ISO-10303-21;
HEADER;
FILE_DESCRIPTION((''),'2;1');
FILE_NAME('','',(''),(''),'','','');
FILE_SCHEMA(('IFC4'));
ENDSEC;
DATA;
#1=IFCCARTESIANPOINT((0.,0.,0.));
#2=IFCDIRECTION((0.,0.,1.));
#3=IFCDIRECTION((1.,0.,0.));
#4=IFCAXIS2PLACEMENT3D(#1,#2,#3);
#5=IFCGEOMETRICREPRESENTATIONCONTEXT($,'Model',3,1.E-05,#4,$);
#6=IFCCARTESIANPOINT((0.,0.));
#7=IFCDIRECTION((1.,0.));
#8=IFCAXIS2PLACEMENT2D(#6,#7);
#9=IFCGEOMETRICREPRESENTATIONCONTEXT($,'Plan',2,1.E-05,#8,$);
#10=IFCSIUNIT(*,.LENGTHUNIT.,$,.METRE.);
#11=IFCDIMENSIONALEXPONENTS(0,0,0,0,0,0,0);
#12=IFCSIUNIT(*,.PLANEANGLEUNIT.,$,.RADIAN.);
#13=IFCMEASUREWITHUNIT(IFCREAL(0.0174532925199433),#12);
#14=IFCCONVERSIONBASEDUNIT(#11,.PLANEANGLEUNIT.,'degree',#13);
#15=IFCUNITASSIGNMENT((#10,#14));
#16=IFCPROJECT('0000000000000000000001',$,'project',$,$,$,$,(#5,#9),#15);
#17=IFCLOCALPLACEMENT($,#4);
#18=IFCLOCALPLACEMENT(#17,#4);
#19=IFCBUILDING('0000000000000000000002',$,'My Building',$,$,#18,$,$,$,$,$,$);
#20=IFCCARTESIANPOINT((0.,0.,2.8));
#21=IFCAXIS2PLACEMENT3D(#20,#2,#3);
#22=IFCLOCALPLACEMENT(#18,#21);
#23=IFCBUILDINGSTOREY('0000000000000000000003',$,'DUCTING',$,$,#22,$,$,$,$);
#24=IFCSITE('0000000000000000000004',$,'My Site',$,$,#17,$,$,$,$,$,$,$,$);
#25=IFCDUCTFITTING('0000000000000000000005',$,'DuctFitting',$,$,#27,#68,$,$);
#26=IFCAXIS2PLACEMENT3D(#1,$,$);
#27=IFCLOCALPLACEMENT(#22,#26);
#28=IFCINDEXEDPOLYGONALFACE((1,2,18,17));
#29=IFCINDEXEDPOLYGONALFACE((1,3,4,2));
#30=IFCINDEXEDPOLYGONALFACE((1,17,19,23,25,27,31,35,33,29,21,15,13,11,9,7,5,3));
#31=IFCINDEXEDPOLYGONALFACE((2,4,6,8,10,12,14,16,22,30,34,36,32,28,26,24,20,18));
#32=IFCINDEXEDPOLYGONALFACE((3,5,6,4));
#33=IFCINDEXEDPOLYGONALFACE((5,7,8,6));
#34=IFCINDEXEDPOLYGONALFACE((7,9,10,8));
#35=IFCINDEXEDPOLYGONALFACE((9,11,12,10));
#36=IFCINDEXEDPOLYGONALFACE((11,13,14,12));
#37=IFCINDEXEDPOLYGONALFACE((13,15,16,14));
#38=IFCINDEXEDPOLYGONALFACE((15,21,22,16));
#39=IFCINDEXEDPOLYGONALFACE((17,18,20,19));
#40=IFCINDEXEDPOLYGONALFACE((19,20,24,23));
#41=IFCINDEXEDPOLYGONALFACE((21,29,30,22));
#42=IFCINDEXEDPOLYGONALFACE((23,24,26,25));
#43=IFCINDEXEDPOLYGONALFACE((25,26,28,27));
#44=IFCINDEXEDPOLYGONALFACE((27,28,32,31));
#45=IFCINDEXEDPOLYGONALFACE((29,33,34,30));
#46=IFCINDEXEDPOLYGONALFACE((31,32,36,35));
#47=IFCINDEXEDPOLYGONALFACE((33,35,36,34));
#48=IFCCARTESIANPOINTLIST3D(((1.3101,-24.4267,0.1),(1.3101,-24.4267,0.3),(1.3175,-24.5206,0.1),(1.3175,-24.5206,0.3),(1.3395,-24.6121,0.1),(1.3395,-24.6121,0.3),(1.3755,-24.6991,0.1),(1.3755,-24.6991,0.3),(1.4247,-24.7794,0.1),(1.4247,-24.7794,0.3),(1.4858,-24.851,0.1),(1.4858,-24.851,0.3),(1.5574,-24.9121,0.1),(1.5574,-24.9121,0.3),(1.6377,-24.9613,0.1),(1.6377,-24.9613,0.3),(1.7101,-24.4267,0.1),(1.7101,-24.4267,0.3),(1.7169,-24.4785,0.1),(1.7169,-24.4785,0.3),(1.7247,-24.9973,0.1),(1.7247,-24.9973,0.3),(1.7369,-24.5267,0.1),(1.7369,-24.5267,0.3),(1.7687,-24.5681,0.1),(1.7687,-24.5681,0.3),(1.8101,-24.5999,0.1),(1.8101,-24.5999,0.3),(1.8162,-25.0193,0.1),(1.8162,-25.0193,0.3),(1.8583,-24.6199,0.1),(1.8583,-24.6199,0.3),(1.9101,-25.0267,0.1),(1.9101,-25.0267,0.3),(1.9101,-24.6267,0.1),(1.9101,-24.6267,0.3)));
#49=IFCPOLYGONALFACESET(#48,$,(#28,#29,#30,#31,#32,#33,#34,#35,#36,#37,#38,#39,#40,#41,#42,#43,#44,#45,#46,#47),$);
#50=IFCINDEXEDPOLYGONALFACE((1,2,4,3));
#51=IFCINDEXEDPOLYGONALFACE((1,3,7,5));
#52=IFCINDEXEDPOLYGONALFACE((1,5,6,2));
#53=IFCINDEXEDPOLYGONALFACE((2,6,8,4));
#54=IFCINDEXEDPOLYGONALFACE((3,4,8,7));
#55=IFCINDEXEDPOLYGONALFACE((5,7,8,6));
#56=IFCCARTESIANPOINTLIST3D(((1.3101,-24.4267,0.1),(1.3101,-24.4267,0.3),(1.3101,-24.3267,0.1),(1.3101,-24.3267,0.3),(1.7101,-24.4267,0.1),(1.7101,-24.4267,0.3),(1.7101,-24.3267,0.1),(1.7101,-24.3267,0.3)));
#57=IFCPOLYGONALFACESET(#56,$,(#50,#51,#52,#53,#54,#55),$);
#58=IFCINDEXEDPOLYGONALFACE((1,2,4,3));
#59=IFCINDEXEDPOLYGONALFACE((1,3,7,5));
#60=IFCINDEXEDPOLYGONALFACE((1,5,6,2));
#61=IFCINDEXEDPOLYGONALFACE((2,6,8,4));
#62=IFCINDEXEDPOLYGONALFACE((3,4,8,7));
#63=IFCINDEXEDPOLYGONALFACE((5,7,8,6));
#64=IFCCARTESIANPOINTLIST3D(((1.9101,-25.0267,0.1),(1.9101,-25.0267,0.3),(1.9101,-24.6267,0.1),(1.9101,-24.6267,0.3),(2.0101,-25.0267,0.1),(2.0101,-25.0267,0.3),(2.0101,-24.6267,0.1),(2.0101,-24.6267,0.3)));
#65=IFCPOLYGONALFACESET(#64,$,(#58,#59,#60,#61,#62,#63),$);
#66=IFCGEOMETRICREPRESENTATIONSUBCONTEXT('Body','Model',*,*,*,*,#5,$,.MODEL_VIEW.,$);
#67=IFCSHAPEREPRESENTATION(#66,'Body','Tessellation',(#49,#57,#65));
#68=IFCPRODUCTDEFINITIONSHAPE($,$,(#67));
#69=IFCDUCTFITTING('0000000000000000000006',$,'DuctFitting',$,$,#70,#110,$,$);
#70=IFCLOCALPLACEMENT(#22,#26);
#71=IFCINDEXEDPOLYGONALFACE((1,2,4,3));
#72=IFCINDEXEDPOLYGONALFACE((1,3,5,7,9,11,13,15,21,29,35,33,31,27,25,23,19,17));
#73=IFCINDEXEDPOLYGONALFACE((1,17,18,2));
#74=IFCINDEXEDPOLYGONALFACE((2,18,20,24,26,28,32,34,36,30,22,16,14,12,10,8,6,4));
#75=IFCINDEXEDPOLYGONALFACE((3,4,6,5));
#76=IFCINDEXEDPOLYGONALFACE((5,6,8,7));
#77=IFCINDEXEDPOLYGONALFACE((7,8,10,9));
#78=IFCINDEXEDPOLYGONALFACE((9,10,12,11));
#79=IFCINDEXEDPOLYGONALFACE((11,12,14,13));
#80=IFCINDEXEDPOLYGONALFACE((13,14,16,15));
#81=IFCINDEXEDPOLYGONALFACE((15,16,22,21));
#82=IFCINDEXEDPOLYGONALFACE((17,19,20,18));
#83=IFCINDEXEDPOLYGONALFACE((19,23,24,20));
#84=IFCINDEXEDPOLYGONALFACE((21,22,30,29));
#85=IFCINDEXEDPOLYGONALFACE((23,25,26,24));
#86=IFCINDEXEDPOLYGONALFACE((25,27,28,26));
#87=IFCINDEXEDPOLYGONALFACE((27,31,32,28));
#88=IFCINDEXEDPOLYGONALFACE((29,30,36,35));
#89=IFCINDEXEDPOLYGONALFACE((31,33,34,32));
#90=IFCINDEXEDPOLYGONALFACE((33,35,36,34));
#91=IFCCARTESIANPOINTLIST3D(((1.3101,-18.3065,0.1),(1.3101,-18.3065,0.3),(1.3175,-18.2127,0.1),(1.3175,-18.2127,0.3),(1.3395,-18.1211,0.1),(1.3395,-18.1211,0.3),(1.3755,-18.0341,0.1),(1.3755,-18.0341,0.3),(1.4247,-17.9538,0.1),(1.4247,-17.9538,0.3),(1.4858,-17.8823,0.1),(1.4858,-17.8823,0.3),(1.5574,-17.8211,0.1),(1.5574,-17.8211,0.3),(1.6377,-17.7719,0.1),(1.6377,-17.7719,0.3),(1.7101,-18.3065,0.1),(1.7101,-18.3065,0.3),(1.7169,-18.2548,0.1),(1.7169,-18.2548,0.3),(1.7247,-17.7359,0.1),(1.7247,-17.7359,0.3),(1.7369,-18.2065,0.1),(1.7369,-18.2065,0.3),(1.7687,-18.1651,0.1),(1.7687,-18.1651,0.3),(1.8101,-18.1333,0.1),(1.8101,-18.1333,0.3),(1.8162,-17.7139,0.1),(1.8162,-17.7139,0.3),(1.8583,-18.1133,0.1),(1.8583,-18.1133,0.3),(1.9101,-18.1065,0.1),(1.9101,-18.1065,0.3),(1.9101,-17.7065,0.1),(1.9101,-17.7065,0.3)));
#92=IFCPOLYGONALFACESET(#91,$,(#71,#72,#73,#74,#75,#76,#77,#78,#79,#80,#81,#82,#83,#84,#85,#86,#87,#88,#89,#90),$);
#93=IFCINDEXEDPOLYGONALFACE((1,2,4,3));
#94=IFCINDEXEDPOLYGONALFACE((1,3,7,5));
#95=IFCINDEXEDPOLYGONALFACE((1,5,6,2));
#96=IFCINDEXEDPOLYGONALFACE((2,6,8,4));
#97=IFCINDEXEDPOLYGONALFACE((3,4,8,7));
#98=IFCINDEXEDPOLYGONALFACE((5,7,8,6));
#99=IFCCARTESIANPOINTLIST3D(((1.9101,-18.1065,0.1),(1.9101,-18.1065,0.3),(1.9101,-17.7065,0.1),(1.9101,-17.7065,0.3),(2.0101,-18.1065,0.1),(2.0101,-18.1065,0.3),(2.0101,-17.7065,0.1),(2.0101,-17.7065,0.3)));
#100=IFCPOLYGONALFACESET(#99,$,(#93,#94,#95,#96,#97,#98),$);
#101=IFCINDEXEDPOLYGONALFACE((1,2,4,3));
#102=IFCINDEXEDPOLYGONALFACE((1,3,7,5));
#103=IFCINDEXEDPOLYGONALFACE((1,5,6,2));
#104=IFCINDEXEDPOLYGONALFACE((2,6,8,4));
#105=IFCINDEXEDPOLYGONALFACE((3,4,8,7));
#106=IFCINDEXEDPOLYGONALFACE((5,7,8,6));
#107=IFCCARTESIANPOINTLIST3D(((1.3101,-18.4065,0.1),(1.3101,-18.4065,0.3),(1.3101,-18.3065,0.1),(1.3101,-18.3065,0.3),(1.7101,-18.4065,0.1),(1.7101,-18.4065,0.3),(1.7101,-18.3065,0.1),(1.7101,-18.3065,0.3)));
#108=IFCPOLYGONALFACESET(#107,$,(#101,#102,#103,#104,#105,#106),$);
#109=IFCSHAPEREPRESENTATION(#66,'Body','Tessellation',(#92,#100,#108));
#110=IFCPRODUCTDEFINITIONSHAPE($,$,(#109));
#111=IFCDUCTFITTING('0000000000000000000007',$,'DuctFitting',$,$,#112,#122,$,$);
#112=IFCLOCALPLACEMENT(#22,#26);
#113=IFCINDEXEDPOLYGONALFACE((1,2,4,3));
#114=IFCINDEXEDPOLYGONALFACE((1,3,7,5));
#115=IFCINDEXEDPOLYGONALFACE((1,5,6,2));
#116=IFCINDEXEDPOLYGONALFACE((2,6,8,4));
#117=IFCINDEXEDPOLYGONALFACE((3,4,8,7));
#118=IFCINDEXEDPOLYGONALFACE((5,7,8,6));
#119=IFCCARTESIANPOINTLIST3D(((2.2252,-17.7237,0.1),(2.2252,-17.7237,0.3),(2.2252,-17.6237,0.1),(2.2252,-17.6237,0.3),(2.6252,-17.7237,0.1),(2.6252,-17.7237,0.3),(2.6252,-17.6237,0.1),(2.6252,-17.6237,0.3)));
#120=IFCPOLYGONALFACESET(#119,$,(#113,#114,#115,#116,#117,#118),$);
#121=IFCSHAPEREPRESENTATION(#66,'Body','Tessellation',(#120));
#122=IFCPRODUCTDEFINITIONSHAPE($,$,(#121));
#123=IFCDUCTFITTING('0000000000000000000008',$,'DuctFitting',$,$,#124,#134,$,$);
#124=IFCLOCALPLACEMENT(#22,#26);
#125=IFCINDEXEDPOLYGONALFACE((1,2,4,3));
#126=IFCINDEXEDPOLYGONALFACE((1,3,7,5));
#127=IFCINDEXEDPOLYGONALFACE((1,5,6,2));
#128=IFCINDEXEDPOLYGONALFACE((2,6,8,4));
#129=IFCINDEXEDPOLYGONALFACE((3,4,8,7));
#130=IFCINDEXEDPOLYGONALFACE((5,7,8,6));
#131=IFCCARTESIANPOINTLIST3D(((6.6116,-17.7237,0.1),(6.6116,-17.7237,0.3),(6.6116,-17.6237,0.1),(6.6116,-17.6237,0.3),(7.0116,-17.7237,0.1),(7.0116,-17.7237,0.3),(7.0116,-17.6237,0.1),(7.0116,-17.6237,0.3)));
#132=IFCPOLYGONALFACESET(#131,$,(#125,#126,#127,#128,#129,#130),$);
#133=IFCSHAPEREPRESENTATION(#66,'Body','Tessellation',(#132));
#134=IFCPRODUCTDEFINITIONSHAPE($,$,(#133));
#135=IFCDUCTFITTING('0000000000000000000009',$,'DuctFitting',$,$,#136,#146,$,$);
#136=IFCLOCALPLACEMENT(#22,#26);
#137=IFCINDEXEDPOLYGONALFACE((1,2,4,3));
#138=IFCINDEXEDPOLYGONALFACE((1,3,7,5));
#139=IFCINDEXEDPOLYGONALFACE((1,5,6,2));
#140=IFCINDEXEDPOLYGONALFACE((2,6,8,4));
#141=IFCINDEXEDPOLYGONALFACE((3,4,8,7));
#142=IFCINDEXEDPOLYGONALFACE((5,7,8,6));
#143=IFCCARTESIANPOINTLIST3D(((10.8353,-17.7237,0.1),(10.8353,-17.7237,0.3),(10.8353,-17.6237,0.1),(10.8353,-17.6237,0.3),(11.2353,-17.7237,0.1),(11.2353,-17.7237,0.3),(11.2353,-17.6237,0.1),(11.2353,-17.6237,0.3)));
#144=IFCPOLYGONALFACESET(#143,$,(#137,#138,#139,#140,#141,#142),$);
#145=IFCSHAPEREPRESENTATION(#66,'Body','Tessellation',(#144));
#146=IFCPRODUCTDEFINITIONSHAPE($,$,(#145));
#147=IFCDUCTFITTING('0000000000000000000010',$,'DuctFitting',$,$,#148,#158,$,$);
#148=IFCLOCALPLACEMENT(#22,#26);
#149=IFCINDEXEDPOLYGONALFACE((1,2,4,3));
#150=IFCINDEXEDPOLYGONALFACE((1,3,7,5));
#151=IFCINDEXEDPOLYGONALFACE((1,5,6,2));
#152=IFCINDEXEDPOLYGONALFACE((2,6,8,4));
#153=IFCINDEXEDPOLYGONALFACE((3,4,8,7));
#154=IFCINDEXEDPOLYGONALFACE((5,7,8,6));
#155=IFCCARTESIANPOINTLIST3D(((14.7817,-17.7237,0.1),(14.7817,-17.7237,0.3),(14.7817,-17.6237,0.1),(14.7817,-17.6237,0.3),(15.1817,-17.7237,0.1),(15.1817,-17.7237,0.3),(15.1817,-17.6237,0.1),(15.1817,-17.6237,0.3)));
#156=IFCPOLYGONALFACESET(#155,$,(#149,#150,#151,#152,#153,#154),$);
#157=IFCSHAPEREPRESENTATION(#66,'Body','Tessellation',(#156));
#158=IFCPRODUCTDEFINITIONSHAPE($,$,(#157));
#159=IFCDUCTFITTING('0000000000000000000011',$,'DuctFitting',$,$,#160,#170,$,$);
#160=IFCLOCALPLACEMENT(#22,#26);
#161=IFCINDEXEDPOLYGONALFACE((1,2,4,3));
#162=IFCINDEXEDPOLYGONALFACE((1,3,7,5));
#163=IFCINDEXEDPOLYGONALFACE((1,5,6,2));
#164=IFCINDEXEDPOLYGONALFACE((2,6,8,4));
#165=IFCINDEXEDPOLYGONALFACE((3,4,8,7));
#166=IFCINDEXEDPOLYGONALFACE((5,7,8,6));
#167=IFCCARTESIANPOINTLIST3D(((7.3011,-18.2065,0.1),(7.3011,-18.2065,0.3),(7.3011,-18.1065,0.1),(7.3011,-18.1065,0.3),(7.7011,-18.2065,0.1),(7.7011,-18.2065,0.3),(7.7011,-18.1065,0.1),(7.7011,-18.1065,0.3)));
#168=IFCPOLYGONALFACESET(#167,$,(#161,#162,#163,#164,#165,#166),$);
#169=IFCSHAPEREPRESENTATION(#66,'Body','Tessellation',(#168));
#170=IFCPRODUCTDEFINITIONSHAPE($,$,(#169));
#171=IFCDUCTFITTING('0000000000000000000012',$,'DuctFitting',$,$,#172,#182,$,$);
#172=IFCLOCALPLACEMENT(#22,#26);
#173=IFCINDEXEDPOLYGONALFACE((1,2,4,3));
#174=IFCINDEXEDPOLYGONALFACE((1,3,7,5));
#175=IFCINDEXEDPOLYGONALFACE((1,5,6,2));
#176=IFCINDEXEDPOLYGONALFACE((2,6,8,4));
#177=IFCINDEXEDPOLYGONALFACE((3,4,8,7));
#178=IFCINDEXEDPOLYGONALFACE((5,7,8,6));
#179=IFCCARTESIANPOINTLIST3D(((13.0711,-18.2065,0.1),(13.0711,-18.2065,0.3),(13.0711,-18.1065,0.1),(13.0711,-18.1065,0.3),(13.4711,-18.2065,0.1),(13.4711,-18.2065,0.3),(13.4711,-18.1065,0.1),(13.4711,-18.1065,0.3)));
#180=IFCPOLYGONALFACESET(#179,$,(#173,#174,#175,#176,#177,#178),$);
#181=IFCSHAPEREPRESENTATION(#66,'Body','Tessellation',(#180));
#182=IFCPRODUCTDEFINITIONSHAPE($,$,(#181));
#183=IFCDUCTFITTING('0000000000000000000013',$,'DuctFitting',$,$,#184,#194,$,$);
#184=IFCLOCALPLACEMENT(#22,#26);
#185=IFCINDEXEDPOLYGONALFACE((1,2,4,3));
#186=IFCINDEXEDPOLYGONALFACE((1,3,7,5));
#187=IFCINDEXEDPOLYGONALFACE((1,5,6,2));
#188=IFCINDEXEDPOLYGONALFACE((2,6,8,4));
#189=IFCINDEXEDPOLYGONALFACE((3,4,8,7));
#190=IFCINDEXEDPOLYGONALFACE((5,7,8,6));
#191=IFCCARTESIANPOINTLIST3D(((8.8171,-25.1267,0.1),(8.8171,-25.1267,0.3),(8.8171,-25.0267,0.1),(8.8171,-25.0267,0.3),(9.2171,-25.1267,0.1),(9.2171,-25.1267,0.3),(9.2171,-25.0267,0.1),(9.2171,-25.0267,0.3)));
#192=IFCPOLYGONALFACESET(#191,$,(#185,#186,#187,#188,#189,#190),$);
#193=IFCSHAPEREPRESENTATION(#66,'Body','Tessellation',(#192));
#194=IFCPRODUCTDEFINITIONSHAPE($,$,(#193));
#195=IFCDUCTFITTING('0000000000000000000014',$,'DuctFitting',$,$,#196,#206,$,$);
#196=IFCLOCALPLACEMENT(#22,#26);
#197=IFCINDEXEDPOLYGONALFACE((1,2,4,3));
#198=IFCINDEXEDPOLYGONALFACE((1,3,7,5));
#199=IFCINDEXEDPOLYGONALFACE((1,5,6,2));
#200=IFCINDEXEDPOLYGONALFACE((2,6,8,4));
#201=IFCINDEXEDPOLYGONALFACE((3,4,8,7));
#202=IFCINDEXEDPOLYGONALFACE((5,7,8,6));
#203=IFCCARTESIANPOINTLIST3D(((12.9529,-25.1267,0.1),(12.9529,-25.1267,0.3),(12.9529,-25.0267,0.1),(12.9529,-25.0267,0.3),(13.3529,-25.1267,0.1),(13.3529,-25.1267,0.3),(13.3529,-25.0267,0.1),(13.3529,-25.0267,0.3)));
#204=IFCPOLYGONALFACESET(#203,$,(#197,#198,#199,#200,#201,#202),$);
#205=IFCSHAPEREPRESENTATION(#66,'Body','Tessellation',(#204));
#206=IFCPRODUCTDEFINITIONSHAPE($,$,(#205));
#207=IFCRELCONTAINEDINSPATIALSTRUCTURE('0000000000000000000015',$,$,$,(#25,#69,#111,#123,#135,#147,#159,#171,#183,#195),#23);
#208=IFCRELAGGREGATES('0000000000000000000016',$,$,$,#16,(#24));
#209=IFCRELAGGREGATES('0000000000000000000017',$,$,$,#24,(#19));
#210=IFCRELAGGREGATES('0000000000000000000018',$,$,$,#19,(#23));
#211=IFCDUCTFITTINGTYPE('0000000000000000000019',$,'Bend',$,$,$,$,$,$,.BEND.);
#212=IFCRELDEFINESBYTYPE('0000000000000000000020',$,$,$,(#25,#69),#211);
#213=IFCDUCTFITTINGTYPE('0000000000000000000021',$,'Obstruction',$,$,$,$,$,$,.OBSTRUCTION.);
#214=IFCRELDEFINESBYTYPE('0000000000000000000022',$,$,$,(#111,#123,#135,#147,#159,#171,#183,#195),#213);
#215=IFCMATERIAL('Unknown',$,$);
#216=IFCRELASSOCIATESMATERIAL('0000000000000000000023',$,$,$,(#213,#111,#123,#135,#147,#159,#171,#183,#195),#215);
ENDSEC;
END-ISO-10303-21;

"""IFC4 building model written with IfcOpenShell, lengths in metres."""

from ifc_helpers import new_model, entity, si_unit, converted_unit, frame, origin_with_axes, origin_2d_with_axis, place, context, subcontext, project, spatial, line, arc, indexed_curve, rectangle, outline, extrude, source, transform, mapped, material, material_profile, profile_set, profile_usage, type_object, type_shapes, element, save


model = new_model("IFC4")

# Units and contexts
model_context = context("Model", 3, precision=1e-05, world=origin_with_axes())
plan_context = context("Plan", 2, precision=1e-05, world=origin_2d_with_axis())
body_context = subcontext(model_context, "Body", "Model", "MODEL_VIEW")
ifc_project = project(units=[si_unit("LENGTHUNIT", "METRE"), converted_unit("PLANEANGLEUNIT", "degree", entity("IfcReal", 0.0174532925199433), si_unit("PLANEANGLEUNIT", "RADIAN"), dimensions=[0, 0, 0, 0, 0, 0, 0])], contexts=[model_context, plan_context])

# Site, building, storey
site_placement = place(None, origin_with_axes())
site = spatial("IfcSite", under=ifc_project, at=site_placement, Name="My Site")
building_placement = place(site_placement, origin_with_axes())
building = spatial("IfcBuilding", under=site, at=building_placement, Name="My Building")
storey_placement = place(building_placement, frame((0.0, 0.0, 2.8), z_axis=(0.0, 0.0, 1.0), x_axis=(1.0, 0.0, 0.0)))
storey = spatial("IfcBuildingStorey", under=building, at=storey_placement, Name="DUCTING")

# Shared definitions
ifc_material = material(Name="Unknown")

# Duct fittings
duct_fitting_type_1 = type_object("IfcDuctFittingType", Name="Bend", PredefinedType="BEND")
shared_shape = source(origin_with_axes(), body_context, "Body", "SweptSolid", [
    extrude(outline(indexed_curve([(-0.2, 0.0), (-0.2586, -0.1414), (-0.4, -0.2), (-0.4, -0.6), (0.0243, -0.4243), (0.2, 0.0)], segments=[arc(1, 2, 3), line(3, 4), arc(4, 5, 6), line(6, 1)])), frame((0.0, -0.1, -0.1), z_axis=(0.0, -1.0, 0.0), x_axis=(1.0, 0.0, 0.0)), (0.0, 0.0, -1.0), 0.2),
    extrude(rectangle(XDim=0.4, YDim=0.2), origin_with_axes(), (0.0, 0.0, -1.0), 0.1),
    extrude(rectangle(XDim=0.4, YDim=0.2), frame((-0.4, 0.0, -0.5), z_axis=(-1.0, 0.0, 0.0), x_axis=(0.0, 0.0, -1.0)), (0.0, 0.0, 1.0), 0.1),
])
type_shapes(duct_fitting_type_1, [shared_shape])
for number, where, z_axis, x_axis, name in (
    (1, (1.5101, -24.3267, 0.2), (0.0, 1.0, 0.0), (-1.0, 0.0, 0.0), "DuctFitting"),
    (2, (2.0101, -17.9065, 0.2), (1.0, 0.0, 0.0), (0.0, 1.0, 0.0), "DuctFitting"),
):
    element("IfcDuctFitting", number, at=place(storey_placement, frame(where, z_axis=z_axis, x_axis=x_axis)), inside=storey, type_object=duct_fitting_type_1, Name=name, context=body_context, shape_type="MappedRepresentation", body=[
        mapped(shared_shape, transform((0.0, 0.0, 0.0), x_axis=(1.0, 0.0, 0.0), y_axis=(0.0, 1.0, 0.0), z_axis=(0.0, 0.0, 1.0), scale=1.0)),
    ])
ifc_material_profile_1 = material_profile(ifc_material, rectangle(XDim=0.4, YDim=0.2))
ifc_profile_set_1 = profile_set([ifc_material_profile_1])
ifc_profile_usage_1 = profile_usage(ifc_profile_set_1, cardinal=5)
duct_fitting_type_2 = type_object("IfcDuctFittingType", Name="Obstruction", PredefinedType="OBSTRUCTION", material=ifc_profile_set_1)
duct_fitting_1_placement = place(storey_placement, frame((2.4252, -17.7237, 0.2), z_axis=(0.0, 1.0, 0.0), x_axis=(-1.0, 0.0, 0.0)))
element("IfcDuctFitting", 3, at=duct_fitting_1_placement, inside=storey, type_object=duct_fitting_type_2, material=ifc_profile_usage_1, Name="DuctFitting", context=body_context, shape_type="SweptSolid", body=[
    extrude(rectangle(XDim=0.4, YDim=0.2), origin_with_axes(), (0.0, 0.0, 1.0), 0.1),
])
ifc_profile_usage_2 = profile_usage(ifc_profile_set_1, cardinal=5)
duct_fitting_2_placement = place(storey_placement, frame((6.8116, -17.7237, 0.2), z_axis=(0.0, 1.0, 0.0), x_axis=(-1.0, 0.0, 0.0)))
element("IfcDuctFitting", 4, at=duct_fitting_2_placement, inside=storey, type_object=duct_fitting_type_2, material=ifc_profile_usage_2, Name="DuctFitting", context=body_context, shape_type="SweptSolid", body=[
    extrude(rectangle(XDim=0.4, YDim=0.2), origin_with_axes(), (0.0, 0.0, 1.0), 0.1),
])
ifc_profile_usage_3 = profile_usage(ifc_profile_set_1, cardinal=5)
duct_fitting_3_placement = place(storey_placement, frame((11.0353, -17.7237, 0.2), z_axis=(0.0, 1.0, 0.0), x_axis=(-1.0, 0.0, 0.0)))
element("IfcDuctFitting", 5, at=duct_fitting_3_placement, inside=storey, type_object=duct_fitting_type_2, material=ifc_profile_usage_3, Name="DuctFitting", context=body_context, shape_type="SweptSolid", body=[
    extrude(rectangle(XDim=0.4, YDim=0.2), origin_with_axes(), (0.0, 0.0, 1.0), 0.1),
])
ifc_profile_usage_4 = profile_usage(ifc_profile_set_1, cardinal=5)
duct_fitting_4_placement = place(storey_placement, frame((14.9817, -17.7237, 0.2), z_axis=(0.0, 1.0, 0.0), x_axis=(-1.0, 0.0, 0.0)))
element("IfcDuctFitting", 6, at=duct_fitting_4_placement, inside=storey, type_object=duct_fitting_type_2, material=ifc_profile_usage_4, Name="DuctFitting", context=body_context, shape_type="SweptSolid", body=[
    extrude(rectangle(XDim=0.4, YDim=0.2), origin_with_axes(), (0.0, 0.0, 1.0), 0.1),
])
ifc_profile_usage_5 = profile_usage(ifc_profile_set_1, cardinal=5)
duct_fitting_5_placement = place(storey_placement, frame((7.5011, -18.1065, 0.2), z_axis=(0.0, -1.0, 0.0), x_axis=(1.0, 0.0, 0.0)))
element("IfcDuctFitting", 7, at=duct_fitting_5_placement, inside=storey, type_object=duct_fitting_type_2, material=ifc_profile_usage_5, Name="DuctFitting", context=body_context, shape_type="SweptSolid", body=[
    extrude(rectangle(XDim=0.4, YDim=0.2), origin_with_axes(), (0.0, 0.0, 1.0), 0.1),
])
ifc_profile_usage_6 = profile_usage(ifc_profile_set_1, cardinal=5)
duct_fitting_6_placement = place(storey_placement, frame((13.2711, -18.1065, 0.2), z_axis=(0.0, -1.0, 0.0), x_axis=(1.0, 0.0, 0.0)))
element("IfcDuctFitting", 8, at=duct_fitting_6_placement, inside=storey, type_object=duct_fitting_type_2, material=ifc_profile_usage_6, Name="DuctFitting", context=body_context, shape_type="SweptSolid", body=[
    extrude(rectangle(XDim=0.4, YDim=0.2), origin_with_axes(), (0.0, 0.0, 1.0), 0.1),
])
ifc_profile_usage_7 = profile_usage(ifc_profile_set_1, cardinal=5)
duct_fitting_7_placement = place(storey_placement, frame((9.0171, -25.0267, 0.2), z_axis=(0.0, -1.0, 0.0), x_axis=(1.0, 0.0, 0.0)))
element("IfcDuctFitting", 9, at=duct_fitting_7_placement, inside=storey, type_object=duct_fitting_type_2, material=ifc_profile_usage_7, Name="DuctFitting", context=body_context, shape_type="SweptSolid", body=[
    extrude(rectangle(XDim=0.4, YDim=0.2), origin_with_axes(), (0.0, 0.0, 1.0), 0.1),
])
ifc_profile_usage_8 = profile_usage(ifc_profile_set_1, cardinal=5)
duct_fitting_8_placement = place(storey_placement, frame((13.1529, -25.0267, 0.2), z_axis=(0.0, -1.0, 0.0), x_axis=(1.0, 0.0, 0.0)))
element("IfcDuctFitting", 10, at=duct_fitting_8_placement, inside=storey, type_object=duct_fitting_type_2, material=ifc_profile_usage_8, Name="DuctFitting", context=body_context, shape_type="SweptSolid", body=[
    extrude(rectangle(XDim=0.4, YDim=0.2), origin_with_axes(), (0.0, 0.0, 1.0), 0.1),
])

save(model, "model.ifc")
